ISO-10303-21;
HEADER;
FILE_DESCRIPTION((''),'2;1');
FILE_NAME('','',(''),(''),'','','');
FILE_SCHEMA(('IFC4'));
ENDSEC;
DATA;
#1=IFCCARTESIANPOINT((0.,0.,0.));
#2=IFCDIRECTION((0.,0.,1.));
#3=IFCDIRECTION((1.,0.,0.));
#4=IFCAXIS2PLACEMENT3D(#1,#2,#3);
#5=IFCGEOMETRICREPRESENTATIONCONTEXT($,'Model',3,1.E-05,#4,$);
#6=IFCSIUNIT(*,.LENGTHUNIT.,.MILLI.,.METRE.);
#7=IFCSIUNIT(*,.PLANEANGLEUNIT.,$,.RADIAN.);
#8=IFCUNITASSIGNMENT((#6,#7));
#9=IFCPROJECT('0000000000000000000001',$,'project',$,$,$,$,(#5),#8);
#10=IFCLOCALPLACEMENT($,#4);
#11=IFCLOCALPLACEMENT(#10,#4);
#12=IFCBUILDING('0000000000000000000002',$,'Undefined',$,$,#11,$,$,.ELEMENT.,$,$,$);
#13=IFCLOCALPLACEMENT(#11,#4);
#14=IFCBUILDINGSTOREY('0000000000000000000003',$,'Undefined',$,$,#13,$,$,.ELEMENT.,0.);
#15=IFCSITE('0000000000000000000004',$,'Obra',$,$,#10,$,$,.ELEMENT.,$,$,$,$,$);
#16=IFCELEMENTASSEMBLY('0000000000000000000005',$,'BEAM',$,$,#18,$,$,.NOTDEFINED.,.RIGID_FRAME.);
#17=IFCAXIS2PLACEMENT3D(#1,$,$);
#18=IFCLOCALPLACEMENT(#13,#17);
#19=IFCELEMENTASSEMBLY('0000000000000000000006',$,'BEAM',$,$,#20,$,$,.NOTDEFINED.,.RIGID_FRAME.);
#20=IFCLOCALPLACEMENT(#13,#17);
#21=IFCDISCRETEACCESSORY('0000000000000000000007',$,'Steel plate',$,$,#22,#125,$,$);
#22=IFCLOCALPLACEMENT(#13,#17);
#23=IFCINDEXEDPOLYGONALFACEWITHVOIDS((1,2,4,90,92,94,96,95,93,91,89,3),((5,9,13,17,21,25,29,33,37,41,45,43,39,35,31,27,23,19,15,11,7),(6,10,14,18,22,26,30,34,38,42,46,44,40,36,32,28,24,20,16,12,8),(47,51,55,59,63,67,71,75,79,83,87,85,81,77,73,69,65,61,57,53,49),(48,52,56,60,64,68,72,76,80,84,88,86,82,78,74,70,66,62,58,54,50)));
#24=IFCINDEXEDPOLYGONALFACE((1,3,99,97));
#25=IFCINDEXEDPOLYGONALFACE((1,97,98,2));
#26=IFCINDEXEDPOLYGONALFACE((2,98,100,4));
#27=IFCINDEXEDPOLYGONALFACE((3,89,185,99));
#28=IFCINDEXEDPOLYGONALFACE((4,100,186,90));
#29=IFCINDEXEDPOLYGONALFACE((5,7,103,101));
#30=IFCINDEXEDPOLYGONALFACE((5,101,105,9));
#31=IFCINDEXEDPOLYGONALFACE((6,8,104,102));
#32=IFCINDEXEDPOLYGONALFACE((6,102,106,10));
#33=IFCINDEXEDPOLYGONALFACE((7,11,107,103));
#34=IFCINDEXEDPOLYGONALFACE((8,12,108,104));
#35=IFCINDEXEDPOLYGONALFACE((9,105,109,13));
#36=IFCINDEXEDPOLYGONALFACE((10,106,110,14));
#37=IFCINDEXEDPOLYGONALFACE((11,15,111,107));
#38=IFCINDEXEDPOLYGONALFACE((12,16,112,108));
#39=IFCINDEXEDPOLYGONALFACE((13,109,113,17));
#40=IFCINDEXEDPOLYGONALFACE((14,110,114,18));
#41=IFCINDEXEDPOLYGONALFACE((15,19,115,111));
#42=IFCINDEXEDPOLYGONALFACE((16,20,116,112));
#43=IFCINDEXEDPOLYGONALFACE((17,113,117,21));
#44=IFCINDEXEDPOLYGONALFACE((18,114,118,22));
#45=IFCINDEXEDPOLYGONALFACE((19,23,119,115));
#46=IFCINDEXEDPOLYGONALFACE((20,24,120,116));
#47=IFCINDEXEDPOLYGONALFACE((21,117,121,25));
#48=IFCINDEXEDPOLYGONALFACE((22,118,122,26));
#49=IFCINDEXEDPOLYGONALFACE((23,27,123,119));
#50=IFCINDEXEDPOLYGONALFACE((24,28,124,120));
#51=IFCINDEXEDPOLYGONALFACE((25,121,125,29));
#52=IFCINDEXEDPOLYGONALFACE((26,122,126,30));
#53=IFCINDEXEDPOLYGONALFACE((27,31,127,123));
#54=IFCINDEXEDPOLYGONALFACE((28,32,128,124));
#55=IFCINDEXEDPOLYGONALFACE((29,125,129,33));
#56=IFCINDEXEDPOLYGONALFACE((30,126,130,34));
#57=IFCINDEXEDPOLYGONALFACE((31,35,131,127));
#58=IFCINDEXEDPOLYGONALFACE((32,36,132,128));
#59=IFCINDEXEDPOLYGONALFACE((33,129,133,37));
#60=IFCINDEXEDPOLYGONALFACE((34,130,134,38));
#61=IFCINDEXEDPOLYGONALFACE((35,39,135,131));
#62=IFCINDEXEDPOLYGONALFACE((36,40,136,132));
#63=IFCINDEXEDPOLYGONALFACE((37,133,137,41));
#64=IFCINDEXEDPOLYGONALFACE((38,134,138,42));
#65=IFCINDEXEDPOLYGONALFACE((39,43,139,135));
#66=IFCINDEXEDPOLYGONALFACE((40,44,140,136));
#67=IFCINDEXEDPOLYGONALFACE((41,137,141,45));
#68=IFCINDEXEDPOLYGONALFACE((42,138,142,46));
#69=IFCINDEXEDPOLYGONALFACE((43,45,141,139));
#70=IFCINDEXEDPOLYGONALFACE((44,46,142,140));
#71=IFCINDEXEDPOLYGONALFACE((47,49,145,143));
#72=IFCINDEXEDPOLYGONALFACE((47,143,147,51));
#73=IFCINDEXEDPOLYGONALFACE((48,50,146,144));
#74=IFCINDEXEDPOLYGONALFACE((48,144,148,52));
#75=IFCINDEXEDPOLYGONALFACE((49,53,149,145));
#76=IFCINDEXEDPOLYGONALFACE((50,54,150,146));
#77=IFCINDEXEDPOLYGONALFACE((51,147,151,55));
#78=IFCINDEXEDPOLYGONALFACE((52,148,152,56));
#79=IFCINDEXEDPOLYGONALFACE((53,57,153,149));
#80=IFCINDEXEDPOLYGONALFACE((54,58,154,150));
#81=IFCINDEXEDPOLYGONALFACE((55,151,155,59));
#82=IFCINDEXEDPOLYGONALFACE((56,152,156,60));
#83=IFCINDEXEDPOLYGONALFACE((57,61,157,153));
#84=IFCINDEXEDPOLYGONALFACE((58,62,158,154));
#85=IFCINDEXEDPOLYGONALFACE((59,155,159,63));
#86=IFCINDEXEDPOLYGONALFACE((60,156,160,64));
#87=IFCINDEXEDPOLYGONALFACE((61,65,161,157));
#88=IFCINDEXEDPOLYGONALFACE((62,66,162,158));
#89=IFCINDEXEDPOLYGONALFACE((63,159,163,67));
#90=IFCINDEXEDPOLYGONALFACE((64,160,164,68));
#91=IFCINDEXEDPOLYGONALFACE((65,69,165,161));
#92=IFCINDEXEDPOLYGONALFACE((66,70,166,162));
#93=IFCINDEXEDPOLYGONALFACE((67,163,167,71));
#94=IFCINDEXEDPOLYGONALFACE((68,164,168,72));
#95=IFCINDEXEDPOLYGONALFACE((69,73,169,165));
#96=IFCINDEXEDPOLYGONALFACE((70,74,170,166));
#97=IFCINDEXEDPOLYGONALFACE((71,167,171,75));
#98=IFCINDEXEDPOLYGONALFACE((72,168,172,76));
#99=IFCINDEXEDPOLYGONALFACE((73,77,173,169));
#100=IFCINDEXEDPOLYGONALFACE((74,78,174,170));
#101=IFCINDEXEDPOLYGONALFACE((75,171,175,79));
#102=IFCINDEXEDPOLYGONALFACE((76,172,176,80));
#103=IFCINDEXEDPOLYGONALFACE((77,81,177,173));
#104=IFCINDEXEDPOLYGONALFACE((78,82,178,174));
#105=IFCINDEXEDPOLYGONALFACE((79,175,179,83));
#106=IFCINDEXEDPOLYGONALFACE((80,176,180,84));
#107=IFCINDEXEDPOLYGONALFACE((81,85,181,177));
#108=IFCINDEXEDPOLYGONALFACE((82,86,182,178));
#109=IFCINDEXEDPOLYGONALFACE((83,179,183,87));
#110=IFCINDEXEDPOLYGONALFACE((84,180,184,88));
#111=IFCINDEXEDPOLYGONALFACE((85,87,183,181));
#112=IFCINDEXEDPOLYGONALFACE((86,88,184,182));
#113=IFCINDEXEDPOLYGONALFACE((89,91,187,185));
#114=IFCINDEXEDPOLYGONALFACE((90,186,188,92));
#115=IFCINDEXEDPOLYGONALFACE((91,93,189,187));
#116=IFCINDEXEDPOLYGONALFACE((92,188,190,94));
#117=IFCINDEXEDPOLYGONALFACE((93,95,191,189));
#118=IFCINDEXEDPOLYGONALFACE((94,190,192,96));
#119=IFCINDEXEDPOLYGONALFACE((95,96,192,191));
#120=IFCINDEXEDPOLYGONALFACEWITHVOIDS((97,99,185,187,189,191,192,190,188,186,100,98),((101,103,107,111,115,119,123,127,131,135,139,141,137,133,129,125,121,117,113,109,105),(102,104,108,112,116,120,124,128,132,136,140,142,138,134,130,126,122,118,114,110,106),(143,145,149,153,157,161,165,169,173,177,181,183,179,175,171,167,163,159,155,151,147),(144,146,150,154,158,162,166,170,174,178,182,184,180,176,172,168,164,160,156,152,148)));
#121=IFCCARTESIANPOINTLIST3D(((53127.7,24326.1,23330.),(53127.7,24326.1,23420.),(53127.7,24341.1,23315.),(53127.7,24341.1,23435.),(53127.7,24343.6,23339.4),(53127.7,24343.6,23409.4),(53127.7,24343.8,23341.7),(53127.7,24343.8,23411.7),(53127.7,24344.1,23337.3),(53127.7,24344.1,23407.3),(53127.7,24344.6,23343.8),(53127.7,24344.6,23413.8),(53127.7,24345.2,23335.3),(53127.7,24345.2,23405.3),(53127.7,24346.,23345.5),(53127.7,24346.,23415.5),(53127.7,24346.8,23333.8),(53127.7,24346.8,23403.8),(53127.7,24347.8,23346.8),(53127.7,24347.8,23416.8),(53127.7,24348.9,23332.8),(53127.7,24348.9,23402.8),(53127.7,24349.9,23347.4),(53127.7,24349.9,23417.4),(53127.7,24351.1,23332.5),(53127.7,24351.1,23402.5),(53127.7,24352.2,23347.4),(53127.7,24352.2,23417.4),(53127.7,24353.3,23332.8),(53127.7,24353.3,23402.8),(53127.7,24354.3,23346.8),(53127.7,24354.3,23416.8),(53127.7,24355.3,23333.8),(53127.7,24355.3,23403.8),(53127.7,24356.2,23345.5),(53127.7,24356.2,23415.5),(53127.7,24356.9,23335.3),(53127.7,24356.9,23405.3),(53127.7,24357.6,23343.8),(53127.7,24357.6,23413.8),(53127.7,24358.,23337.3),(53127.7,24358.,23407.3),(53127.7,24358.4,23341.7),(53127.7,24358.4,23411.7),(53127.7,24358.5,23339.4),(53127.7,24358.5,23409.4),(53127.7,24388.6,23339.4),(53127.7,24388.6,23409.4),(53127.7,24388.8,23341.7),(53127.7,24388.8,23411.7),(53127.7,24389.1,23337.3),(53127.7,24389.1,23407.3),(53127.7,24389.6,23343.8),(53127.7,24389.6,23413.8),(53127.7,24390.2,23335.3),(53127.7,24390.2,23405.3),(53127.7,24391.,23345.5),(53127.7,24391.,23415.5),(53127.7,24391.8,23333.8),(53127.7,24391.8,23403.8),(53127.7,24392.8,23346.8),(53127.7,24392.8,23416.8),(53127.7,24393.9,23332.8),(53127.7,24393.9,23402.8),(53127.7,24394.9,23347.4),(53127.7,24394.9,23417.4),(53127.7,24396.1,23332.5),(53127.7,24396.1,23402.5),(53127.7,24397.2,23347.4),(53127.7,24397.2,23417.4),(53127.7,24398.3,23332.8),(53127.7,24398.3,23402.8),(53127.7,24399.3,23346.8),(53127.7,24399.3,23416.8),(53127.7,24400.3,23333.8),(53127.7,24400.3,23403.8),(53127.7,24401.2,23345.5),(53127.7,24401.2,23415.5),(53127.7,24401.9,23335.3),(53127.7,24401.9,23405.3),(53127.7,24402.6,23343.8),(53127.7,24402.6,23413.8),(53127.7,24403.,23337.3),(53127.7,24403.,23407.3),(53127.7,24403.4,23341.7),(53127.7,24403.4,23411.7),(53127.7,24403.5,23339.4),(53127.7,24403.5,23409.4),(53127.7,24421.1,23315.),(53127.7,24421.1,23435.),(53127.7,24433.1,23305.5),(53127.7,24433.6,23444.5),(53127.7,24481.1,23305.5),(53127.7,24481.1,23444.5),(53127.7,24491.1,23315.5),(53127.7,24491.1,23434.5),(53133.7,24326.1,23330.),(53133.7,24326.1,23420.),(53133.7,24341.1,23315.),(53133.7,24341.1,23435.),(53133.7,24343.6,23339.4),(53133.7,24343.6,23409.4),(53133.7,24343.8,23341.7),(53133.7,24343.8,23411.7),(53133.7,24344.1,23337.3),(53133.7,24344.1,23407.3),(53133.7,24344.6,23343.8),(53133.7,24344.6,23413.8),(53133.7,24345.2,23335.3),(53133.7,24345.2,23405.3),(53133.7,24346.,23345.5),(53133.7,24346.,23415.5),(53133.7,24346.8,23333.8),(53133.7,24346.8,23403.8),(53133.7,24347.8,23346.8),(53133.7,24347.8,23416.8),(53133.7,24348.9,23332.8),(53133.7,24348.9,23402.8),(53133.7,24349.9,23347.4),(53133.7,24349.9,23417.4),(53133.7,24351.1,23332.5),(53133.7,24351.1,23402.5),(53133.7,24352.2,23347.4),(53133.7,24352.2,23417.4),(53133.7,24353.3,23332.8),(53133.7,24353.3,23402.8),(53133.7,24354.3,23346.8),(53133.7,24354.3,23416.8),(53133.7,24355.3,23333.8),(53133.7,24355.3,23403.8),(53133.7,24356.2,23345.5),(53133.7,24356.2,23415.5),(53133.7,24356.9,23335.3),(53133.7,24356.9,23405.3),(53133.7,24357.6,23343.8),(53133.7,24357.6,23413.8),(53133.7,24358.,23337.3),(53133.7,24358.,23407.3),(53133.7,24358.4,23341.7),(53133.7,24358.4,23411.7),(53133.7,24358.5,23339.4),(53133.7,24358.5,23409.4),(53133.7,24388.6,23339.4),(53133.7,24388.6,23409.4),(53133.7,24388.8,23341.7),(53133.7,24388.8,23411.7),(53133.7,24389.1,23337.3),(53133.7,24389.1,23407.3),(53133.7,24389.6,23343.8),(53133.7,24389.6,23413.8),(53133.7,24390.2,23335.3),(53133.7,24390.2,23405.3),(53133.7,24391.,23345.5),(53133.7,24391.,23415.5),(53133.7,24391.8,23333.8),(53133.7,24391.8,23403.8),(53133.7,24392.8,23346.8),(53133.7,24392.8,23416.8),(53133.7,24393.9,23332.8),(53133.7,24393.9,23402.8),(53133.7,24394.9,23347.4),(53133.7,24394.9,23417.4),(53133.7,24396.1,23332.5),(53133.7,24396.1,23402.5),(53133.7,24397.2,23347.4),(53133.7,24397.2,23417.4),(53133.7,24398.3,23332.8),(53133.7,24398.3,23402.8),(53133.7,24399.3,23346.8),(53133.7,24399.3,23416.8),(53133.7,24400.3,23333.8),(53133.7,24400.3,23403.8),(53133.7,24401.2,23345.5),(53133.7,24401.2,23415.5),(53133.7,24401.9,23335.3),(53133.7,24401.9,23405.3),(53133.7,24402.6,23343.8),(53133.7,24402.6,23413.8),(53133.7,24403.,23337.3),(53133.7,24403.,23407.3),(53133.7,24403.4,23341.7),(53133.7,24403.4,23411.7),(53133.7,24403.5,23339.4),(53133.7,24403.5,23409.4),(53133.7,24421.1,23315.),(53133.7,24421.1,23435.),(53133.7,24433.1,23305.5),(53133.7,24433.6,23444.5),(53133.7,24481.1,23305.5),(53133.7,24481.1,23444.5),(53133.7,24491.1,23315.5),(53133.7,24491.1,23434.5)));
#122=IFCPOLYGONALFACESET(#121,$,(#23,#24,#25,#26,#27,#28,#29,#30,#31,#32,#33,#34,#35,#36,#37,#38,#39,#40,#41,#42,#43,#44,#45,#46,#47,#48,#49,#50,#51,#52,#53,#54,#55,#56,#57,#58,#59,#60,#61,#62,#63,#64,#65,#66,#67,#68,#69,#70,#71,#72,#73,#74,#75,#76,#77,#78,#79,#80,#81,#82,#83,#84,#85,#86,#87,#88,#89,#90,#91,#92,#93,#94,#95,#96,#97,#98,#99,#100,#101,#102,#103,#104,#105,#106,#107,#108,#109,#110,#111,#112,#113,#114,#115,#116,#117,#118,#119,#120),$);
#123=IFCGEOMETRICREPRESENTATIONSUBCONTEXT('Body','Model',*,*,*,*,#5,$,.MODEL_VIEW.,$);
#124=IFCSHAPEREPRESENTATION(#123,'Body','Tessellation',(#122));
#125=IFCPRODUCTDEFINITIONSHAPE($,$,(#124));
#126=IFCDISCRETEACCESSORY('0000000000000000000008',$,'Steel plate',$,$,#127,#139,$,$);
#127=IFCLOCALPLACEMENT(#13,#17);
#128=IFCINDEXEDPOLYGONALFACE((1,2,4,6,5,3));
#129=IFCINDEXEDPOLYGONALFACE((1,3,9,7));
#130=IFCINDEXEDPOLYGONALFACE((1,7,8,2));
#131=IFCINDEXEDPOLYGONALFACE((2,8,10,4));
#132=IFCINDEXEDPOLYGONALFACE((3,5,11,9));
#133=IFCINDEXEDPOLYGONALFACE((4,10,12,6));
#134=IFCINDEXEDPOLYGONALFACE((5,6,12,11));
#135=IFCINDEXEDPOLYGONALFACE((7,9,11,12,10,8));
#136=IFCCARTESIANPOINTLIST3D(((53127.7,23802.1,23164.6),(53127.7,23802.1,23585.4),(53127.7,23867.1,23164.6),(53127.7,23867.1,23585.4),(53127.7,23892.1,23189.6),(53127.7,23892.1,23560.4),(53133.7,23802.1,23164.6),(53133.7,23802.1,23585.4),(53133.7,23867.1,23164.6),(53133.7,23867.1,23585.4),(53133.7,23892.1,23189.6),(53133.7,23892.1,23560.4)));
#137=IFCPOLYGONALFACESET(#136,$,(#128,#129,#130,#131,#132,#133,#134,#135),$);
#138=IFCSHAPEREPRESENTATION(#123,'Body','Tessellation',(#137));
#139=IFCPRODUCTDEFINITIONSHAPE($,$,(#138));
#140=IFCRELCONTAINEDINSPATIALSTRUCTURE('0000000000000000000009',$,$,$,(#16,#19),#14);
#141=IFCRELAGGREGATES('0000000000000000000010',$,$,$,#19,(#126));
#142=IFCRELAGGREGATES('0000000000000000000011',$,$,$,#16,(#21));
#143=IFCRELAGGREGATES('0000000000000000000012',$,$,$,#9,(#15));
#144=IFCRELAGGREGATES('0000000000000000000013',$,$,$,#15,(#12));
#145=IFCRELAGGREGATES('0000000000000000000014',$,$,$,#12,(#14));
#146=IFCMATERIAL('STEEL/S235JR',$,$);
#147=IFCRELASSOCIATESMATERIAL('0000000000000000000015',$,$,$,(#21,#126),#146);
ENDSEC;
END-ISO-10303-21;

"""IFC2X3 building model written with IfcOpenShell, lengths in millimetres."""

from ifc_helpers import new_model, si_unit, frame, origin_with_axes, origin_2d_with_axis, place, context, subcontext, project, spatial, polyline, circle, outline, extrude, source, transform, mapped, material, element, aggregate, save


model = new_model("IFC2X3")

# Units and contexts
model_context = context("Model", 3, precision=1e-05, world=origin_with_axes())
body_context = subcontext(model_context, "Body", "Model", "MODEL_VIEW")
ifc_project = project(units=[si_unit("LENGTHUNIT", "METRE", prefix="MILLI"), si_unit("PLANEANGLEUNIT", "RADIAN")], contexts=[model_context])

# Site, building, storey
site_placement = place(None, origin_with_axes())
site = spatial("IfcSite", under=ifc_project, at=site_placement, Name="Obra", CompositionType="ELEMENT")
building_placement = place(site_placement, origin_with_axes())
building = spatial("IfcBuilding", under=site, at=building_placement, Name="Undefined", CompositionType="ELEMENT")
storey_placement = place(building_placement, origin_with_axes())
storey = spatial("IfcBuildingStorey", under=building, at=storey_placement, Name="Undefined", CompositionType="ELEMENT", Elevation=0.0)

# Shared definitions
ifc_material_1 = material(Name="STEEL/S235JR")

# Element assembly
assembly_1_placement = place(storey_placement, origin_with_axes())
assembly_1 = element("IfcElementAssembly", 1, at=assembly_1_placement, inside=storey, Name="BEAM", AssemblyPlace="NOTDEFINED", PredefinedType="RIGID_FRAME")

# Shared definitions
shared_shape_1 = source(origin_with_axes(), body_context, "Body", "SweptSolid", [
    extrude(circle(Radius=7.5, at=origin_2d_with_axis()), frame((0.0, 2.4, 0.0), z_axis=(0.0, 1.0, 0.0), x_axis=(1.0, 0.0, 0.0)), (0.0, 0.0, 1.0), 6.2),
])

# Element assembly
assembly_2_placement = place(storey_placement, origin_with_axes())
assembly_2 = element("IfcElementAssembly", 2, at=assembly_2_placement, inside=storey, Name="BEAM", AssemblyPlace="NOTDEFINED", PredefinedType="RIGID_FRAME")

# Discrete accessory, opening
discrete_accessory_1_placement = place(assembly_1_placement, frame((53130.7, 24491.1, 23315.5), z_axis=(-1.0, 0.0, 0.0), x_axis=(0.000001, -0.707107, -0.707107)))
discrete_accessory_1 = element("IfcDiscreteAccessory", 3, at=discrete_accessory_1_placement, material=ifc_material_1, Name="Steel plate", context=body_context, shape_type="SweptSolid", body=[
    extrude(outline(polyline([(0.0, 0.0), (14.1, 0.0), (48.1, 33.9), (49.9, 49.1), (106.4, 105.7), (106.4, 126.9), (42.8, 190.6), (21.6, 190.6), (-35.0, 134.0), (-50.6, 131.9), (-84.1, 98.3), (-84.1, 84.1), (0.0, 0.0)])), frame((0.0, 0.0, -3.0), z_axis=(0.0, 0.0, 1.0), x_axis=(1.0, 0.0, 0.0)), (0.0, 0.0, 1.0), 6.0),
])
opening_1_placement = place(assembly_1_placement, frame((53125.2, 24373.6, 23410.0), z_axis=(0.0, -1.0, 0.0), x_axis=(0.0, 0.0, -1.0)))
element("IfcOpeningElement", 4, at=opening_1_placement, cuts=discrete_accessory_1, ObjectType="Opening", context=body_context, shape_type="MappedRepresentation", body=[
    mapped(shared_shape_1, transform((0.0, 0.0, -22.5))),
    mapped(shared_shape_1, transform((70.0, 0.0, -22.5))),
    mapped(shared_shape_1, transform((0.0, 0.0, 22.5))),
    mapped(shared_shape_1, transform((70.0, 0.0, 22.5))),
])

# Discrete accessory
discrete_accessory_2_placement = place(assembly_2_placement, frame((53130.7, 23892.1, 23164.6), z_axis=(-1.0, 0.0, 0.0), x_axis=(0.0, -1.0, 0.0)))
discrete_accessory_2 = element("IfcDiscreteAccessory", 5, at=discrete_accessory_2_placement, material=ifc_material_1, Name="Steel plate", context=body_context, shape_type="SweptSolid", body=[
    extrude(outline(polyline([(0.0, 25.0), (25.0, 0.0), (90.0, 0.0), (90.0, 420.8), (25.0, 420.8), (0.0, 395.8), (0.0, 25.0)])), frame((0.0, 0.0, -3.0), z_axis=(0.0, 0.0, 1.0), x_axis=(1.0, 0.0, 0.0)), (0.0, 0.0, 1.0), 6.0),
])

aggregate(assembly_2, [discrete_accessory_2])

aggregate(assembly_1, [discrete_accessory_1])

save(model, "model.ifc")
